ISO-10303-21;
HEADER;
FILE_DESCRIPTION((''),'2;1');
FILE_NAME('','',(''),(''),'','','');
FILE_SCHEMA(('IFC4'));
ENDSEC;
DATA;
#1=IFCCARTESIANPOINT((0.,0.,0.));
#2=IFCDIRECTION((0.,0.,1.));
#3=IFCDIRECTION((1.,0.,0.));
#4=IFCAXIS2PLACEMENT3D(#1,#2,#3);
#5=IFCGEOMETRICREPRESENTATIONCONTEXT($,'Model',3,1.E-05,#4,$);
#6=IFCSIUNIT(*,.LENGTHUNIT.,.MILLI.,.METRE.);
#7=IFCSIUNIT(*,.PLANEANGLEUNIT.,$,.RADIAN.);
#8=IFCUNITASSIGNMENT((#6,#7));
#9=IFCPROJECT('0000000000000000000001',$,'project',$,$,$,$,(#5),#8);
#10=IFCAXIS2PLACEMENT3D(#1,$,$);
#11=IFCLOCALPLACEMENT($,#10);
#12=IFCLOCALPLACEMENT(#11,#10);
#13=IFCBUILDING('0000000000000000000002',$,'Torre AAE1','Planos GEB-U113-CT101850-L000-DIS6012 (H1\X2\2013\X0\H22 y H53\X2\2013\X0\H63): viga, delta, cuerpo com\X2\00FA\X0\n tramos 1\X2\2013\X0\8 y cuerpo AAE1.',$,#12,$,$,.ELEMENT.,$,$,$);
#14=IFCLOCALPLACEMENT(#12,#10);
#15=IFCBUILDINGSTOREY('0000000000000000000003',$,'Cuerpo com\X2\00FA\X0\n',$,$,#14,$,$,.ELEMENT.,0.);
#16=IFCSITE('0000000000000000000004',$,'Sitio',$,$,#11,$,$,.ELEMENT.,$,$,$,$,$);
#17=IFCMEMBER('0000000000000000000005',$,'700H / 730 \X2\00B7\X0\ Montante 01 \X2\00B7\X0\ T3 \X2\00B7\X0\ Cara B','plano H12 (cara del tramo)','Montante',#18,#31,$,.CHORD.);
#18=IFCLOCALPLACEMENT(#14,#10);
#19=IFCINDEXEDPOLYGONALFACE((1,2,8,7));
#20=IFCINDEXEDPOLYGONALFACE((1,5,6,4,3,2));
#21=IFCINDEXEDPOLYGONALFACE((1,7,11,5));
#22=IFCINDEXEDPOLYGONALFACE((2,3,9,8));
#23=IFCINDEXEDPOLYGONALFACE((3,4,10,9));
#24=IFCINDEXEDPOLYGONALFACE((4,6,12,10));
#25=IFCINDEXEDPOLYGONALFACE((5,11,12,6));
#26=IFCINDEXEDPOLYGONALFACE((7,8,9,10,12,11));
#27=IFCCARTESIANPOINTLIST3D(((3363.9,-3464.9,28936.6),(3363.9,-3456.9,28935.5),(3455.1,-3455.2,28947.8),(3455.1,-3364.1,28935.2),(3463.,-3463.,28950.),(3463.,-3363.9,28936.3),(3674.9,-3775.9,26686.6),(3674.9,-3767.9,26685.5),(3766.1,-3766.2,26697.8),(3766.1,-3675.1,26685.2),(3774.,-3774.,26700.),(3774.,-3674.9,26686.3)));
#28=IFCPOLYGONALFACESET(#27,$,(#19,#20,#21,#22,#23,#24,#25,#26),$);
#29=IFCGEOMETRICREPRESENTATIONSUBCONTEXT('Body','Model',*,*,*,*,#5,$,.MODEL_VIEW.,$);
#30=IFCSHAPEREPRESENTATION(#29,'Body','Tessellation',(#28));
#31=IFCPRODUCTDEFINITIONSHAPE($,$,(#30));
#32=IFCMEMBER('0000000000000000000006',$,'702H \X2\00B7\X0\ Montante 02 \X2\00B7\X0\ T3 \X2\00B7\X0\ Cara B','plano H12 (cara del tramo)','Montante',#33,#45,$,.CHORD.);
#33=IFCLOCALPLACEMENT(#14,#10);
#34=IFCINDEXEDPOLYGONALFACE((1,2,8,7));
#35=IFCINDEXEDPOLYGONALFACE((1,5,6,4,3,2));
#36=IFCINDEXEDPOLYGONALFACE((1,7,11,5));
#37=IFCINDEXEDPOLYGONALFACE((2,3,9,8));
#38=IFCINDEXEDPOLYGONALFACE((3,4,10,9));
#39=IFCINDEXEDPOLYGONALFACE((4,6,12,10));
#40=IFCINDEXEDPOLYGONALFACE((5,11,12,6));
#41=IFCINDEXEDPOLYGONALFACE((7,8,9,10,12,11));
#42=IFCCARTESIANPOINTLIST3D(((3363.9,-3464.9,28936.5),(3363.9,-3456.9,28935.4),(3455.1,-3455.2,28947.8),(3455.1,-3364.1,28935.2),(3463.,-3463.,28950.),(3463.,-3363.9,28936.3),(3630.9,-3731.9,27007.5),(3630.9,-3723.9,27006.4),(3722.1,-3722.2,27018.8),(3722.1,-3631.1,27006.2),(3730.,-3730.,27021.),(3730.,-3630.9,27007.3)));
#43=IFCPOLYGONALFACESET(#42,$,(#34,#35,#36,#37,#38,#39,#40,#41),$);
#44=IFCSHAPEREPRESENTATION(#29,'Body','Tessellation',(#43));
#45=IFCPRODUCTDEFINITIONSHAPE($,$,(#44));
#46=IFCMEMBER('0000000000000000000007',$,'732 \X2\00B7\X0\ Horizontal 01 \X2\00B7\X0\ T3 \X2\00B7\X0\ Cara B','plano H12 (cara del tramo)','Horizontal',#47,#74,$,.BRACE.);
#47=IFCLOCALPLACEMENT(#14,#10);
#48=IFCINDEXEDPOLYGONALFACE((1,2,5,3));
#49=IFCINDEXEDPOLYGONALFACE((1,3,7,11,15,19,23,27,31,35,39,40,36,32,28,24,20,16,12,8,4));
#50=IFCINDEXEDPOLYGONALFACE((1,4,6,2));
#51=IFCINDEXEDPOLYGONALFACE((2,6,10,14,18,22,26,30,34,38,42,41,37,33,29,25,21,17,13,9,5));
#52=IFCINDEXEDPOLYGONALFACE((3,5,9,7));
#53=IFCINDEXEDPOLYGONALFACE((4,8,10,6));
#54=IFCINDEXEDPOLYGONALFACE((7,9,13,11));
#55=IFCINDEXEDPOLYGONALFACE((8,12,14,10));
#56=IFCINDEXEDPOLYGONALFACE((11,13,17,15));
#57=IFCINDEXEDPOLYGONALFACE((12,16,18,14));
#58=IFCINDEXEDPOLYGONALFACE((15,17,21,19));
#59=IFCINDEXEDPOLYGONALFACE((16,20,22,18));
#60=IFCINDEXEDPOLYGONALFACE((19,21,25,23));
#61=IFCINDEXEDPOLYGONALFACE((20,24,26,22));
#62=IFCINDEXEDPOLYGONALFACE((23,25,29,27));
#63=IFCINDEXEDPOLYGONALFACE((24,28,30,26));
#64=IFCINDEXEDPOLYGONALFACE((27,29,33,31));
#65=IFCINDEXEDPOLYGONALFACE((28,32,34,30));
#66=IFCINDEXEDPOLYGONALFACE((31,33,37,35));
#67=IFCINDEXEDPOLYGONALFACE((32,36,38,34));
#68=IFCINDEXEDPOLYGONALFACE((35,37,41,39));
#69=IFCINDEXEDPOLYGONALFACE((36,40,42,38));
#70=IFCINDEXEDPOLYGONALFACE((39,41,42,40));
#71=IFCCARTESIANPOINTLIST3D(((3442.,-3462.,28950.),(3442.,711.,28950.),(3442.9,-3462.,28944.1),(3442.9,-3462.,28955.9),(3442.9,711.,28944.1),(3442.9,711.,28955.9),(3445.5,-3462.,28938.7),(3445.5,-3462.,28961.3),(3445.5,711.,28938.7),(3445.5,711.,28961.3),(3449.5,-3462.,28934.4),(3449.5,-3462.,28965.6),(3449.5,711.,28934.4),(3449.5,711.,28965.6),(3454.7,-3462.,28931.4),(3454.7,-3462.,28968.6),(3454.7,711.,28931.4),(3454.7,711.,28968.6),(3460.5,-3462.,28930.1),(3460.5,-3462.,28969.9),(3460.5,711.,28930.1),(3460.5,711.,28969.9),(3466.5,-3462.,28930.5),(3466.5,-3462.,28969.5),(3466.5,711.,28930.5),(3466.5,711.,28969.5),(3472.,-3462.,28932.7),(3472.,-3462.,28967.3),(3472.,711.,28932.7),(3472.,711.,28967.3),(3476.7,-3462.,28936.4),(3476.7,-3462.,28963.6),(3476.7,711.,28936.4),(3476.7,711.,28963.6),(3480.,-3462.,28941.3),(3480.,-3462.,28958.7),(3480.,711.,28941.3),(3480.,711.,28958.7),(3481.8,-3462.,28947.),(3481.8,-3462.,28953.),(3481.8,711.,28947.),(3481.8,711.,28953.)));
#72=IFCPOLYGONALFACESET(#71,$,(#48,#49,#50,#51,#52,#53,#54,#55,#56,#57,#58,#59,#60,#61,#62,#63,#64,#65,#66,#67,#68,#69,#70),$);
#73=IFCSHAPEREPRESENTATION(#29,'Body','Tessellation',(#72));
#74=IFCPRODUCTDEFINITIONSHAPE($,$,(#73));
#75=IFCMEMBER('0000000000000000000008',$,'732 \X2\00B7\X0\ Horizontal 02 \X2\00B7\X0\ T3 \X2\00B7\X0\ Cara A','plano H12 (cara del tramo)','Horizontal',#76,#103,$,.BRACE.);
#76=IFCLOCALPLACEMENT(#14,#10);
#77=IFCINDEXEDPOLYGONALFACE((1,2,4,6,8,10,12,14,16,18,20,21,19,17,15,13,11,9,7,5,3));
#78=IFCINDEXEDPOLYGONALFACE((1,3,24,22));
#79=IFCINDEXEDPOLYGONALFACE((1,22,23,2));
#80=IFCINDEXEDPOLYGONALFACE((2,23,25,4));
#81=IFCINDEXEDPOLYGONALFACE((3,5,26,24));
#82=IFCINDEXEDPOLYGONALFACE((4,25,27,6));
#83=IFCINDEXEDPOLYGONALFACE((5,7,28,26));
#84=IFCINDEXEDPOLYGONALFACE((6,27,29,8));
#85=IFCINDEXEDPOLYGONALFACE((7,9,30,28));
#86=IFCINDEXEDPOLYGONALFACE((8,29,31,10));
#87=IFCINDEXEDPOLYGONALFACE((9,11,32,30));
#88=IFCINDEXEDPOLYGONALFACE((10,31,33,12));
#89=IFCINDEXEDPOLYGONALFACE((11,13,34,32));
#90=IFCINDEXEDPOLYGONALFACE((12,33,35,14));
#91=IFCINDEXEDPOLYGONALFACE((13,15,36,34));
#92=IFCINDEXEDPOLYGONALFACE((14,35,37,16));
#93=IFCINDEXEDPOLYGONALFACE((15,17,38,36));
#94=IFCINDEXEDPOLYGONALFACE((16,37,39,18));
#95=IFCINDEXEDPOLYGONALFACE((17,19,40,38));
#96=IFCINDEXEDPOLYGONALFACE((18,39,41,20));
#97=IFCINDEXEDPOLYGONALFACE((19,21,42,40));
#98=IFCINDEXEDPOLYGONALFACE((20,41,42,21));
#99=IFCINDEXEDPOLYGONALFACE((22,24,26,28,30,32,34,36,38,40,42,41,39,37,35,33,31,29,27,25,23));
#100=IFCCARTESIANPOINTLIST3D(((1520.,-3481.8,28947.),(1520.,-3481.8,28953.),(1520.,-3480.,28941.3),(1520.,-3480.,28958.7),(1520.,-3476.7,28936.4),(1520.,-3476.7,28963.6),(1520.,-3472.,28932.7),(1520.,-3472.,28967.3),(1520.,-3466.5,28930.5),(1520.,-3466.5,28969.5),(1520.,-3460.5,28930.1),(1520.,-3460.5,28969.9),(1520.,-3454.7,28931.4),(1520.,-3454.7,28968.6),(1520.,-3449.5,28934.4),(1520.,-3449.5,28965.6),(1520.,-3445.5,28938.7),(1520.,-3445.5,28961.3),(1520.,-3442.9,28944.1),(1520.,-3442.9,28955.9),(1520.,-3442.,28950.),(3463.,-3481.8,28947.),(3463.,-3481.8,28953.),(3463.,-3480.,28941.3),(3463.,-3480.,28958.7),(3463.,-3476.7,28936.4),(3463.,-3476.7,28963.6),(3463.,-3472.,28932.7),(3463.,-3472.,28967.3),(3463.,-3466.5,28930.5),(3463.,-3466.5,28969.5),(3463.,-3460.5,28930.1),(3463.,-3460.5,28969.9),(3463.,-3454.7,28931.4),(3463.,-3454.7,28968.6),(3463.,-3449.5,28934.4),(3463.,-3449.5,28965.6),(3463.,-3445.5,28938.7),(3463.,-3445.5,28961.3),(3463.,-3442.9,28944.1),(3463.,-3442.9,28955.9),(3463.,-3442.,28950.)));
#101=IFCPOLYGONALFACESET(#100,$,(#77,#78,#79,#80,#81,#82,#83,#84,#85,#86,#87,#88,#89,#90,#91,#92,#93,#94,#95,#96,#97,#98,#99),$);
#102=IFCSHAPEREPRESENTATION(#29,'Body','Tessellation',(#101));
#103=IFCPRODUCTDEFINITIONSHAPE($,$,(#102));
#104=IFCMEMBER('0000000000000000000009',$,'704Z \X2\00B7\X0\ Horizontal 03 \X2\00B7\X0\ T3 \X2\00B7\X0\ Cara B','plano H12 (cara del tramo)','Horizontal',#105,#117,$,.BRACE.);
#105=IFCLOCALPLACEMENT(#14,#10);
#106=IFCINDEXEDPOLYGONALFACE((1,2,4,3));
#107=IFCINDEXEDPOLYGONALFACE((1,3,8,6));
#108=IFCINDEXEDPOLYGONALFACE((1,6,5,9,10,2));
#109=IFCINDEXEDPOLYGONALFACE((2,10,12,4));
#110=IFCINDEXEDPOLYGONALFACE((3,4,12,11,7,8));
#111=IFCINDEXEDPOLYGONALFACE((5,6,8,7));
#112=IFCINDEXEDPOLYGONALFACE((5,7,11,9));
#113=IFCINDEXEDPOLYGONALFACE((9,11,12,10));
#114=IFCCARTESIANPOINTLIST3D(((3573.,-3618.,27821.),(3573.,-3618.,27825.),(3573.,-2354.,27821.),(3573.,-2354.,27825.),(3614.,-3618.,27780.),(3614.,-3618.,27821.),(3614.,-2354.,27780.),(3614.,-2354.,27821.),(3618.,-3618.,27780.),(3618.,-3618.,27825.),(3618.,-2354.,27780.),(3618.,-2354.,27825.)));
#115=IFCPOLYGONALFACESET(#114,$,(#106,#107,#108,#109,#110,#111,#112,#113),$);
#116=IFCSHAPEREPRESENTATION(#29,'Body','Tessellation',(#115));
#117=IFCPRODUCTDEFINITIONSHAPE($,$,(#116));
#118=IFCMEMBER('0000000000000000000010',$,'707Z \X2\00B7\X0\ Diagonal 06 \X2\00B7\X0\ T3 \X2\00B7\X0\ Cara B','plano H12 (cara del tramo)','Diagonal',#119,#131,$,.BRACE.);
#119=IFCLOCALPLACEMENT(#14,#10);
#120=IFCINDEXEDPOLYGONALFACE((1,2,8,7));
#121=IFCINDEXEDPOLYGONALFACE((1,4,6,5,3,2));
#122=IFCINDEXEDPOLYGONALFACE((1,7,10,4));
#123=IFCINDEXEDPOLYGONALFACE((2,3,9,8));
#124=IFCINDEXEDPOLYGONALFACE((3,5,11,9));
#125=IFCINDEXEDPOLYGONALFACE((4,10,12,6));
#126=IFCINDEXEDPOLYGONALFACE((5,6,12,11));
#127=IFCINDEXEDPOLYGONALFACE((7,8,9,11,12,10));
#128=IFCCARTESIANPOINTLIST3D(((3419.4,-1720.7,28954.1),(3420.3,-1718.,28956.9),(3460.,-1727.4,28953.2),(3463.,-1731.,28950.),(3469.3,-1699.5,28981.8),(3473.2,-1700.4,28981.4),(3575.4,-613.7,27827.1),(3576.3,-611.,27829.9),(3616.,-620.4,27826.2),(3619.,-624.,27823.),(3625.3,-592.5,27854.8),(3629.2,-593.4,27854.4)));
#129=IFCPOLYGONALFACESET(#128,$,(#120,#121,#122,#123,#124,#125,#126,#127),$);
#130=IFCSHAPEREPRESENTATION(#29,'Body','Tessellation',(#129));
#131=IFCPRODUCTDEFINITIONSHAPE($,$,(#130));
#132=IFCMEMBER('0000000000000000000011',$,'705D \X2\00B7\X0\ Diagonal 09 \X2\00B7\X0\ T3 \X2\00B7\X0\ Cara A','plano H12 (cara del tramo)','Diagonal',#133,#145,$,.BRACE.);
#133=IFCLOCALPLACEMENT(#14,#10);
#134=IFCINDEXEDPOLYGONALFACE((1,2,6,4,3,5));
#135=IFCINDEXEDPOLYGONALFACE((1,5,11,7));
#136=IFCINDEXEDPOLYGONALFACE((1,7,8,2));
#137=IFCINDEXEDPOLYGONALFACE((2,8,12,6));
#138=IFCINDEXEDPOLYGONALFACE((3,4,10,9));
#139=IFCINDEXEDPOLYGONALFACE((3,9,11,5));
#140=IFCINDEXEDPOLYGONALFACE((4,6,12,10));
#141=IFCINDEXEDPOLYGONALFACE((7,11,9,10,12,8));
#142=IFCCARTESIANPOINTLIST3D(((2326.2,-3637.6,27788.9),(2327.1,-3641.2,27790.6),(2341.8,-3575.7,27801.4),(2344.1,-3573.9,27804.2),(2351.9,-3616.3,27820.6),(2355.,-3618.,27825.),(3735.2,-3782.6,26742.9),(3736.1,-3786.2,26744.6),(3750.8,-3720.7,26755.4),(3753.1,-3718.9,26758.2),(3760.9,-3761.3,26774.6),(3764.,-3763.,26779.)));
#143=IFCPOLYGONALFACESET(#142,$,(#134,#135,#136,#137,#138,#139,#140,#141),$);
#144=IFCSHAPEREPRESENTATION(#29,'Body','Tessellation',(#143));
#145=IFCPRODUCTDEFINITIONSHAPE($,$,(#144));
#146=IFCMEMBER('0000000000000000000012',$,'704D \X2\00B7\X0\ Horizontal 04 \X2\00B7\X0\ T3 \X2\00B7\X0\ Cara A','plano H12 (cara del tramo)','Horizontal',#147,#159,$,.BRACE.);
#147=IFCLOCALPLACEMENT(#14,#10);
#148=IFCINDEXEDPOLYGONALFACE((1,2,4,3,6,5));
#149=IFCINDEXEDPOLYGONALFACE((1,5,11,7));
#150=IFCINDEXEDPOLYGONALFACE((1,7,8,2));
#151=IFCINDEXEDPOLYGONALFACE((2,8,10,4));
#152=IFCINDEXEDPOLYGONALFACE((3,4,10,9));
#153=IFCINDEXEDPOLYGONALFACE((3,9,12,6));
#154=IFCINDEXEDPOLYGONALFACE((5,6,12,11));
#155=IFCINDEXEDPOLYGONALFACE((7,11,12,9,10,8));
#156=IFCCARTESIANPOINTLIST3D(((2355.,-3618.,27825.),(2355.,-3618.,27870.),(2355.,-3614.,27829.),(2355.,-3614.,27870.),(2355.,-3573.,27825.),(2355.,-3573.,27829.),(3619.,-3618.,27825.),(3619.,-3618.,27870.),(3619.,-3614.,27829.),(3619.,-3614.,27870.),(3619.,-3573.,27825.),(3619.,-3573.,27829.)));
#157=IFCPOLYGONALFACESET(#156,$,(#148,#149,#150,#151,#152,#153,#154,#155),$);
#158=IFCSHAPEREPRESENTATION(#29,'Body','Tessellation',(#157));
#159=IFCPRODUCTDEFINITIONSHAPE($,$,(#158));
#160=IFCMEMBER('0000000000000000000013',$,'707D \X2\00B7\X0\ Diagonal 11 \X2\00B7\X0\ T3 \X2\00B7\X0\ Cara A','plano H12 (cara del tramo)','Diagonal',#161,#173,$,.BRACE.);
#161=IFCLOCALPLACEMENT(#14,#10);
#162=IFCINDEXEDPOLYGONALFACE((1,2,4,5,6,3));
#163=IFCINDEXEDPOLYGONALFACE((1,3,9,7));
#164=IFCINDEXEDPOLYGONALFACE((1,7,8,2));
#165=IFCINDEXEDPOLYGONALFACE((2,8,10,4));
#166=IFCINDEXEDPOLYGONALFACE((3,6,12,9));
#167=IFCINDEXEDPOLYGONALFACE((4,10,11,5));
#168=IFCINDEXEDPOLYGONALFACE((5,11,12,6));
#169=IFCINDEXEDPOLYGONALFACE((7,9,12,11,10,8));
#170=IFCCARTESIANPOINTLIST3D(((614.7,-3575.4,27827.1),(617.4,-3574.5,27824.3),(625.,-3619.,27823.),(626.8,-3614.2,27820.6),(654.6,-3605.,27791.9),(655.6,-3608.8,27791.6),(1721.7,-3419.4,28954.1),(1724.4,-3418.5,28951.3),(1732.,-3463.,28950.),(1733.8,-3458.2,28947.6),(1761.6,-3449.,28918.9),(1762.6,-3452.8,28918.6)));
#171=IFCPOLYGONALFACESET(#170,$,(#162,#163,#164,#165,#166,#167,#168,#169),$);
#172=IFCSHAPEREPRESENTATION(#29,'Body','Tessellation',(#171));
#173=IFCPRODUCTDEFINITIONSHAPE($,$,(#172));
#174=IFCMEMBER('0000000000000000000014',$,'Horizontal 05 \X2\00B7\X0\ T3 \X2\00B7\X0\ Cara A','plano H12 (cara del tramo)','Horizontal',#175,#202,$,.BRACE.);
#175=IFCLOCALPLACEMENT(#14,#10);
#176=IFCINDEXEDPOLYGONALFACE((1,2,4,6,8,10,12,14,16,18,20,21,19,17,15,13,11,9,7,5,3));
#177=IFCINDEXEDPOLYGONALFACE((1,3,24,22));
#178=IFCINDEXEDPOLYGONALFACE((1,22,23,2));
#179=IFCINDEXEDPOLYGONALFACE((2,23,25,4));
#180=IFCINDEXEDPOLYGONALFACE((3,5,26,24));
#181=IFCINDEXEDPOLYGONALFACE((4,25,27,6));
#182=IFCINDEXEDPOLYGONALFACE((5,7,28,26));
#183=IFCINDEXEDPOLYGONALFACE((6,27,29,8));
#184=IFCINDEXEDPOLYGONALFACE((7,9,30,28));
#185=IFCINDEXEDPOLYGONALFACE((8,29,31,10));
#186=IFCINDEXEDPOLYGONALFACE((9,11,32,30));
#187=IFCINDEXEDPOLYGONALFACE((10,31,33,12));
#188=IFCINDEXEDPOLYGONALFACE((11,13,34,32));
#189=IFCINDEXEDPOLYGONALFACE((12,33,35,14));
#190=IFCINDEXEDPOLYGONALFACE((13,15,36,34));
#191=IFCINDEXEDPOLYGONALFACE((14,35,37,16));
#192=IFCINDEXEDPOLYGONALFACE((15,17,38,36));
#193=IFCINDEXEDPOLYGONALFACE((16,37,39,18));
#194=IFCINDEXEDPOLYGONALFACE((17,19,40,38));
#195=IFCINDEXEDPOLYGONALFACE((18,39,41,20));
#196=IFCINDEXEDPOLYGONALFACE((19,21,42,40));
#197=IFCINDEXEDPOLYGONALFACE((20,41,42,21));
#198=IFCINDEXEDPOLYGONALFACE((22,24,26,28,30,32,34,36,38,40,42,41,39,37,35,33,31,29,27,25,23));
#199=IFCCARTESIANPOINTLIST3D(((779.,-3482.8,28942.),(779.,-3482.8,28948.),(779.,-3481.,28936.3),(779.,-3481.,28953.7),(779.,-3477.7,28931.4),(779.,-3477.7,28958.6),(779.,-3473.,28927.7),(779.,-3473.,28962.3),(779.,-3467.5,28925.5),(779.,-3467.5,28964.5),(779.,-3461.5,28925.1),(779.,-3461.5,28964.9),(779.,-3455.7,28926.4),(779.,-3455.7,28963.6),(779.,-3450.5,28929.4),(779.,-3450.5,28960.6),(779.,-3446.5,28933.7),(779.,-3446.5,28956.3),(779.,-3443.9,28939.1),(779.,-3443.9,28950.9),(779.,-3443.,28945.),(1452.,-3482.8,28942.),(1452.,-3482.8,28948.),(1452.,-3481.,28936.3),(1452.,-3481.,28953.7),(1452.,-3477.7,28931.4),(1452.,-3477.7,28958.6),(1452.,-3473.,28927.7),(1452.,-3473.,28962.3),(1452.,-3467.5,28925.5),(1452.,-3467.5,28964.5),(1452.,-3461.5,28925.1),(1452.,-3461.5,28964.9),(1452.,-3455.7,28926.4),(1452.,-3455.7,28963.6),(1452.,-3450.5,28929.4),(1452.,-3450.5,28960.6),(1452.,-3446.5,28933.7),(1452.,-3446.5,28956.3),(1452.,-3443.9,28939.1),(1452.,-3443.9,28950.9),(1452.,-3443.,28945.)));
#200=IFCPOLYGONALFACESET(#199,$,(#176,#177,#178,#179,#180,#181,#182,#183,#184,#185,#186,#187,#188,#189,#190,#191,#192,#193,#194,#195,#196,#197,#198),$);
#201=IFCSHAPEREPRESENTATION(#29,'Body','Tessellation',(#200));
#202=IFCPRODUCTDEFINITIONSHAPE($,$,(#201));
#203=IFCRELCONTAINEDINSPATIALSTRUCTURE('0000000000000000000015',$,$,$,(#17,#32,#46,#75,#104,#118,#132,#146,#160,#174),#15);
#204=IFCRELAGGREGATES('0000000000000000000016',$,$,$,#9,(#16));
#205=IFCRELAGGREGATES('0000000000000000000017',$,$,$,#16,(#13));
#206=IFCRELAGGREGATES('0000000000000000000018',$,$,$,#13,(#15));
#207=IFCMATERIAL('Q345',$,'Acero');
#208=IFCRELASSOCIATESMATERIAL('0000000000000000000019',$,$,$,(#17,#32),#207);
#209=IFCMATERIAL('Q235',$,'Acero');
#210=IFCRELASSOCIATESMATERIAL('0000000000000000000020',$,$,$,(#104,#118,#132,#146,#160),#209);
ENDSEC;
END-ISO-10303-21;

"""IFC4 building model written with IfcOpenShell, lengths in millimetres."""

from ifc_helpers import new_model, si_unit, frame, frame_2d, origin, origin_with_axes, place, context, subcontext, project, spatial, circle, l_section, extrude, material, element, save


model = new_model("IFC4")

# Units and contexts
model_context = context("Model", 3, precision=1e-05, world=origin_with_axes())
body_context = subcontext(model_context, "Body", "Model", "MODEL_VIEW")
ifc_project = project(units=[si_unit("LENGTHUNIT", "METRE", prefix="MILLI"), si_unit("PLANEANGLEUNIT", "RADIAN")], contexts=[model_context])

# Site, building, storey
site_placement = place(None, origin())
site = spatial("IfcSite", under=ifc_project, at=site_placement, Name="Sitio", CompositionType="ELEMENT")
building_placement = place(site_placement, origin())
building = spatial("IfcBuilding", under=site, at=building_placement, Name="Torre AAE1", Description="Planos GEB-U113-CT101850-L000-DIS6012 (H1–H22 y H53–H63): viga, delta, cuerpo común tramos 1–8 y cuerpo AAE1.", CompositionType="ELEMENT")
storey_placement = place(building_placement, origin())
storey = spatial("IfcBuildingStorey", under=building, at=storey_placement, Name="Cuerpo común", CompositionType="ELEMENT", Elevation=0.0)

# Members
ifc_material_1 = material(Name="Q235", Category="Acero")
ifc_material_2 = material(Name="Q345", Category="Acero")
member_1_placement = place(storey_placement, frame((3463.0, -3463.0, 28950.0), z_axis=(0.135655, -0.135655, -0.981425), x_axis=(-0.990756, -0.018574, -0.134377)))
element("IfcMember", 1, at=member_1_placement, inside=storey, material=ifc_material_2, Name="700H / 730 · Montante 01 · T3 · Cara B", Description="plano H12 (cara del tramo)", ObjectType="Montante", PredefinedType="CHORD", context=body_context, shape_type="SweptSolid", body=[
    extrude(l_section(Depth=100.0, Width=100.0, Thickness=8.0, at=frame_2d((50.0, 50.0))), None, (0.0, 0.0, 1.0), 2292.6),
])
member_2_placement = place(storey_placement, frame((3463.0, -3463.0, 28950.0), z_axis=(0.135836, -0.135836, -0.981375), x_axis=(-0.990731, -0.018624, -0.134553)))
element("IfcMember", 2, at=member_2_placement, inside=storey, material=ifc_material_2, Name="702H · Montante 02 · T3 · Cara B", Description="plano H12 (cara del tramo)", ObjectType="Montante", PredefinedType="CHORD", context=body_context, shape_type="SweptSolid", body=[
    extrude(l_section(Depth=100.0, Width=100.0, Thickness=8.0, at=frame_2d((50.0, 50.0))), None, (0.0, 0.0, 1.0), 1965.6),
])
member_3_placement = place(storey_placement, frame((3462.0, -3462.0, 28950.0), z_axis=(0.0, 1.0, 0.0), x_axis=(-1.0, 0.0, 0.0)))
element("IfcMember", 3, at=member_3_placement, inside=storey, Name="732 · Horizontal 01 · T3 · Cara B", Description="plano H12 (cara del tramo)", ObjectType="Horizontal", PredefinedType="BRACE", context=body_context, shape_type="SweptSolid", body=[
    extrude(circle(Radius=20.0), None, (0.0, 0.0, 1.0), 4173.0),
])
member_4_placement = place(storey_placement, frame((1520.0, -3462.0, 28950.0), z_axis=(1.0, 0.0, 0.0), x_axis=(0.0, 1.0, 0.0)))
element("IfcMember", 4, at=member_4_placement, inside=storey, Name="732 · Horizontal 02 · T3 · Cara A", Description="plano H12 (cara del tramo)", ObjectType="Horizontal", PredefinedType="BRACE", context=body_context, shape_type="SweptSolid", body=[
    extrude(circle(Radius=20.0), None, (0.0, 0.0, 1.0), 1943.0),
])
member_5_placement = place(storey_placement, frame((3618.0, -2354.0, 27825.0), z_axis=(0.0, -1.0, 0.0), x_axis=(-1.0, 0.0, 0.0)))
element("IfcMember", 5, at=member_5_placement, inside=storey, material=ifc_material_1, Name="704Z · Horizontal 03 · T3 · Cara B", Description="plano H12 (cara del tramo)", ObjectType="Horizontal", PredefinedType="BRACE", context=body_context, shape_type="SweptSolid", body=[
    extrude(l_section(Depth=45.0, Width=45.0, Thickness=4.0, at=frame_2d((22.5, 22.5))), None, (0.0, 0.0, 1.0), 1264.0),
])
member_6_placement = place(storey_placement, frame((3463.0, -1731.0, 28950.0), z_axis=(0.098272, 0.697356, -0.709955), x_axis=(-0.969194, 0.228971, 0.090751)))
element("IfcMember", 6, at=member_6_placement, inside=storey, material=ifc_material_1, Name="707Z · Diagonal 06 · T3 · Cara B", Description="plano H12 (cara del tramo)", ObjectType="Diagonal", PredefinedType="BRACE", context=body_context, shape_type="SweptSolid", body=[
    extrude(l_section(Depth=45.0, Width=45.0, Thickness=4.0, at=frame_2d((22.5, 22.5))), None, (0.0, 0.0, 1.0), 1587.4),
])
member_7_placement = place(storey_placement, frame((3764.0, -3763.0, 26779.0), z_axis=(-0.800204, 0.082349, 0.594048), x_axis=(-0.2184, 0.8825, -0.416528)))
element("IfcMember", 7, at=member_7_placement, inside=storey, material=ifc_material_1, Name="705D · Diagonal 09 · T3 · Cara A", Description="plano H12 (cara del tramo)", ObjectType="Diagonal", PredefinedType="BRACE", context=body_context, shape_type="SweptSolid", body=[
    extrude(l_section(Depth=50.0, Width=50.0, Thickness=4.0, at=frame_2d((25.0, 25.0))), None, (0.0, 0.0, 1.0), 1760.8),
])
member_8_placement = place(storey_placement, frame((2355.0, -3618.0, 27825.0), z_axis=(1.0, 0.0, 0.0), x_axis=(0.0, 1.0, 0.0)))
element("IfcMember", 8, at=member_8_placement, inside=storey, material=ifc_material_1, Name="704D · Horizontal 04 · T3 · Cara A", Description="plano H12 (cara del tramo)", ObjectType="Horizontal", PredefinedType="BRACE", context=body_context, shape_type="SweptSolid", body=[
    extrude(l_section(Depth=45.0, Width=45.0, Thickness=4.0, at=frame_2d((22.5, 22.5))), None, (0.0, 0.0, 1.0), 1264.0),
])
member_9_placement = place(storey_placement, frame((1732.0, -3463.0, 28950.0), z_axis=(-0.697356, -0.098272, -0.709955), x_axis=(-0.229096, 0.969152, 0.090879)))
element("IfcMember", 9, at=member_9_placement, inside=storey, material=ifc_material_1, Name="707D · Diagonal 11 · T3 · Cara A", Description="plano H12 (cara del tramo)", ObjectType="Diagonal", PredefinedType="BRACE", context=body_context, shape_type="SweptSolid", body=[
    extrude(l_section(Depth=45.0, Width=45.0, Thickness=4.0, at=frame_2d((22.5, 22.5))), None, (0.0, 0.0, 1.0), 1587.4),
])
member_10_placement = place(storey_placement, frame((779.0, -3463.0, 28945.0), z_axis=(1.0, 0.0, 0.0), x_axis=(0.0, 1.0, 0.0)))
element("IfcMember", 10, at=member_10_placement, inside=storey, Name="Horizontal 05 · T3 · Cara A", Description="plano H12 (cara del tramo)", ObjectType="Horizontal", PredefinedType="BRACE", context=body_context, shape_type="SweptSolid", body=[
    extrude(circle(Radius=20.0), None, (0.0, 0.0, 1.0), 673.0),
])

save(model, "model.ifc")
